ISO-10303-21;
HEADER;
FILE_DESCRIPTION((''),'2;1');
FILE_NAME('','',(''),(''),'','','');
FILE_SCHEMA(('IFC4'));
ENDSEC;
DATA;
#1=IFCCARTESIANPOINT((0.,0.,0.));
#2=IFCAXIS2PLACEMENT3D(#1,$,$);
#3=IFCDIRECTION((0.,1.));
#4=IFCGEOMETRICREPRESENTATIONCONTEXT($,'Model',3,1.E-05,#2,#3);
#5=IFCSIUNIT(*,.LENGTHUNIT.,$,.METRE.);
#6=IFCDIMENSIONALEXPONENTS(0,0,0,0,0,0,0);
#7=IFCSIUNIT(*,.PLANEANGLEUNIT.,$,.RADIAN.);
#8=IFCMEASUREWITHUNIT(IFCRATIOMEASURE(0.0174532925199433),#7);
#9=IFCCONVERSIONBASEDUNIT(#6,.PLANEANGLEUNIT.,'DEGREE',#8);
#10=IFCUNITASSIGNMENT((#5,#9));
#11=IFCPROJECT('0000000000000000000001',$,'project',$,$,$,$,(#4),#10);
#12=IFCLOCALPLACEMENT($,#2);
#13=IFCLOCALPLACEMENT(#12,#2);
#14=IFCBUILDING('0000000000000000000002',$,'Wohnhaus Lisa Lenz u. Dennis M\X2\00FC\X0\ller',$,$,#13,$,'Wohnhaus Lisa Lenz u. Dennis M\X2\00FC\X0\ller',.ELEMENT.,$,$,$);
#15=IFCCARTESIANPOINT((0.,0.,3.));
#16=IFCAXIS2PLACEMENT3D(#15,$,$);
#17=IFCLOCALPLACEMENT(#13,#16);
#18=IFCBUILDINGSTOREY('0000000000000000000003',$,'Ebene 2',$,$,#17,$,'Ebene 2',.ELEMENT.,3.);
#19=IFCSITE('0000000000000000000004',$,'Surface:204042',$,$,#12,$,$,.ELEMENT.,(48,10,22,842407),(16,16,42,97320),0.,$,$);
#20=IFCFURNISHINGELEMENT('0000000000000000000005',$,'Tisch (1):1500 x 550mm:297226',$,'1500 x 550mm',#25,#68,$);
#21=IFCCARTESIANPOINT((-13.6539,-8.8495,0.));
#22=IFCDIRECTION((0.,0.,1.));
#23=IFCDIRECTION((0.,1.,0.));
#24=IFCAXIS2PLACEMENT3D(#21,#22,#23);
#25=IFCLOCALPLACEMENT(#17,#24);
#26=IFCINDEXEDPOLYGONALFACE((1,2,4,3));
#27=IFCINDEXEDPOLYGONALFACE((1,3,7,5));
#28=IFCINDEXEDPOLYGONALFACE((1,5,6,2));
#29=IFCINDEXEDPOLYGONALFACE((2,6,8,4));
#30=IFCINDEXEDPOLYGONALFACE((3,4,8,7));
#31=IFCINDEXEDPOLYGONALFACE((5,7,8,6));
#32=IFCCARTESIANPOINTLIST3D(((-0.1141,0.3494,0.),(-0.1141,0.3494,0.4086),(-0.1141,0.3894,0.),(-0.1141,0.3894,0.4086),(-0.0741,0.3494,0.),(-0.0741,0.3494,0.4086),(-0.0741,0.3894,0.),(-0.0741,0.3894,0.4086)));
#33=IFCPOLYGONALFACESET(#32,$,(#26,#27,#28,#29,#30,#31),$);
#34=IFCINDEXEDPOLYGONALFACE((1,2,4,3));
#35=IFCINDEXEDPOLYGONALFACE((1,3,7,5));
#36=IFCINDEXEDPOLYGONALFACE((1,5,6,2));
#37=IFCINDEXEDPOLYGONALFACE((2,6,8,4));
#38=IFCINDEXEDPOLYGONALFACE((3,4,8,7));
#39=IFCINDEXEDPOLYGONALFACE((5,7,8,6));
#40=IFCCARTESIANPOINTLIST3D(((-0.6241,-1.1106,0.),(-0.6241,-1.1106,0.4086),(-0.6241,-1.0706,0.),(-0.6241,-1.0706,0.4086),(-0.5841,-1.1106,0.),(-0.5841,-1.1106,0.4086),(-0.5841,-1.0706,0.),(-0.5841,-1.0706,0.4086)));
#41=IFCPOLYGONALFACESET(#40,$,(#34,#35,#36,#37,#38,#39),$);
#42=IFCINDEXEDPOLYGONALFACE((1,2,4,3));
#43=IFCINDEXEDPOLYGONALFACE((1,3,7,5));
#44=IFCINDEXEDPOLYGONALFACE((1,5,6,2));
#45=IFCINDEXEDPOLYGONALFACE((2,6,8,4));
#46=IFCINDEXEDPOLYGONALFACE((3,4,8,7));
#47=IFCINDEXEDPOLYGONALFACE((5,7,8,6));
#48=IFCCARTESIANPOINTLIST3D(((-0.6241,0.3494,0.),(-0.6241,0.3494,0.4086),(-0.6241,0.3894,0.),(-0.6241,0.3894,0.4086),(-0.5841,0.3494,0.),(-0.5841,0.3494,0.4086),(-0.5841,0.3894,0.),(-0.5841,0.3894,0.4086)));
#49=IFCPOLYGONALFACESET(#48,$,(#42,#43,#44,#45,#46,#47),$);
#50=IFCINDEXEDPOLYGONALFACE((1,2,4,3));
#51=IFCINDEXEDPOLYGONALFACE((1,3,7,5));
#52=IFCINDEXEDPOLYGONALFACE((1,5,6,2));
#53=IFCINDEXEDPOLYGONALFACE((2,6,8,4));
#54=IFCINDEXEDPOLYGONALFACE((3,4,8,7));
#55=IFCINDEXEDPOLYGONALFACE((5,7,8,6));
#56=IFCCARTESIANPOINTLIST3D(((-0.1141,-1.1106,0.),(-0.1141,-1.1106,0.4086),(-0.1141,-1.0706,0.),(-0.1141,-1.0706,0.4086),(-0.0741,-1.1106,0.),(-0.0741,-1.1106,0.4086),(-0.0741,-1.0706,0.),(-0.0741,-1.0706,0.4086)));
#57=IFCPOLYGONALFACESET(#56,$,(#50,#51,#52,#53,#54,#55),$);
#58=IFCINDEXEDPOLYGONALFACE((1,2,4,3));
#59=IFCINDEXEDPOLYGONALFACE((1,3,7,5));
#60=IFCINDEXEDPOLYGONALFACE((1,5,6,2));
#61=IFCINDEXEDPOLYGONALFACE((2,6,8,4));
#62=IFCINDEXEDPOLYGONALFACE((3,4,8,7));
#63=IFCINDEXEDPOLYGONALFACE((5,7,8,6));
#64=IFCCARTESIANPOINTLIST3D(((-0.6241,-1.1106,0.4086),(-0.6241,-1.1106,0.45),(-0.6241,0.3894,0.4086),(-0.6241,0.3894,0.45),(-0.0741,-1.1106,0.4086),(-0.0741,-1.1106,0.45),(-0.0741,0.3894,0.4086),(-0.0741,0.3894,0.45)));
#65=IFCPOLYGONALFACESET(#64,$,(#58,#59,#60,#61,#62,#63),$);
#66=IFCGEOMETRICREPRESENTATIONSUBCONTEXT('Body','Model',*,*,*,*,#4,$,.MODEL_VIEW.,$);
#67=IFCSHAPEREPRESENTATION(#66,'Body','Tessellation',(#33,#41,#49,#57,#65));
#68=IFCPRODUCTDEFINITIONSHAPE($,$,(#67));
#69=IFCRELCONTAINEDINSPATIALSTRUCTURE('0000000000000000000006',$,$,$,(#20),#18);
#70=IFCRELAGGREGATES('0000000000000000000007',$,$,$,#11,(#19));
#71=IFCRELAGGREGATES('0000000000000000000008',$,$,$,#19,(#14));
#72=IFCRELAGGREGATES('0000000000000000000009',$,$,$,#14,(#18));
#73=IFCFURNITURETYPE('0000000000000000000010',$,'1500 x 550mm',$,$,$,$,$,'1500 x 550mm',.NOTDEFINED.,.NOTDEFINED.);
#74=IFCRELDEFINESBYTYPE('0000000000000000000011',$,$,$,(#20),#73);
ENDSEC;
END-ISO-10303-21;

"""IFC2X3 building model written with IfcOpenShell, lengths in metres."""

from ifc_helpers import new_model, entity, si_unit, converted_unit, direction, frame, origin, origin_2d_with_axis, place, context, subcontext, project, spatial, rectangle, extrude, source, transform, mapped, type_object, type_shapes, element, save


model = new_model("IFC2X3")

# Units and contexts
model_context = context("Model", 3, precision=1e-05, world=origin(), true_north=direction((0.0, 1.0)))
body_context = subcontext(model_context, "Body", "Model", "MODEL_VIEW")
ifc_project = project(units=[si_unit("LENGTHUNIT", "METRE"), converted_unit("PLANEANGLEUNIT", "DEGREE", entity("IfcRatioMeasure", 0.0174532925199433), si_unit("PLANEANGLEUNIT", "RADIAN"), dimensions=[0, 0, 0, 0, 0, 0, 0])], contexts=[model_context])

# Site, building, storey
site_placement = place(None, origin())
site = spatial("IfcSite", under=ifc_project, at=site_placement, Name="Surface:204042", CompositionType="ELEMENT", RefLatitude=(48, 10, 22, 842407), RefLongitude=(16, 16, 42, 97320), RefElevation=0.0)
building_placement = place(site_placement, origin())
building = spatial("IfcBuilding", under=site, at=building_placement, Name="Wohnhaus Lisa Lenz u. Dennis Müller", LongName="Wohnhaus Lisa Lenz u. Dennis Müller", CompositionType="ELEMENT")
storey_placement = place(building_placement, frame((0.0, 0.0, 3.0)))
storey = spatial("IfcBuildingStorey", under=building, at=storey_placement, Name="Ebene 2", LongName="Ebene 2", CompositionType="ELEMENT", Elevation=3.0)

# Furnishing element
furniture_type_1 = type_object("IfcFurnitureType", Name="1500 x 550mm", ElementType="1500 x 550mm")
shared_shape_1 = source(origin(), body_context, "Body", "SweptSolid", [
    extrude(rectangle(XDim=0.04, YDim=0.04, at=origin_2d_with_axis()), frame((-0.0941, 0.3694, 0.0), z_axis=(0.0, 0.0, 1.0), x_axis=(-1.0, 0.0, 0.0)), (0.0, 0.0, 1.0), 0.4086),
    extrude(rectangle(XDim=0.04, YDim=0.04, at=origin_2d_with_axis()), frame((-0.6041, -1.0906, 0.0), z_axis=(0.0, 0.0, 1.0), x_axis=(0.0, -1.0, 0.0)), (0.0, 0.0, 1.0), 0.4086),
    extrude(rectangle(XDim=0.04, YDim=0.04, at=origin_2d_with_axis()), frame((-0.6041, 0.3694, 0.0), z_axis=(0.0, 0.0, 1.0), x_axis=(-1.0, 0.0, 0.0)), (0.0, 0.0, 1.0), 0.4086),
    extrude(rectangle(XDim=0.04, YDim=0.04, at=origin_2d_with_axis()), frame((-0.0941, -1.0906, 0.0), z_axis=(0.0, 0.0, 1.0), x_axis=(-1.0, 0.0, 0.0)), (0.0, 0.0, 1.0), 0.4086),
    extrude(rectangle(XDim=0.55, YDim=1.5, at=origin_2d_with_axis()), frame((-0.3491, -0.3606, 0.4086), z_axis=(0.0, 0.0, 1.0), x_axis=(-1.0, 0.0, 0.0)), (0.0, 0.0, 1.0), 0.0414),
])
type_shapes(furniture_type_1, [shared_shape_1])
furnishing_1_placement = place(storey_placement, frame((-13.6539, -8.8495, 0.0), z_axis=(0.0, 0.0, 1.0), x_axis=(0.0, 1.0, 0.0)))
element("IfcFurnishingElement", 1, at=furnishing_1_placement, inside=storey, type_object=furniture_type_1, Name="Tisch (1):1500 x 550mm:297226", ObjectType="1500 x 550mm", context=body_context, shape_type="MappedRepresentation", body=[
    mapped(shared_shape_1, transform((0.0, 0.0, 0.0), scale=1.0)),
])

save(model, "model.ifc")
